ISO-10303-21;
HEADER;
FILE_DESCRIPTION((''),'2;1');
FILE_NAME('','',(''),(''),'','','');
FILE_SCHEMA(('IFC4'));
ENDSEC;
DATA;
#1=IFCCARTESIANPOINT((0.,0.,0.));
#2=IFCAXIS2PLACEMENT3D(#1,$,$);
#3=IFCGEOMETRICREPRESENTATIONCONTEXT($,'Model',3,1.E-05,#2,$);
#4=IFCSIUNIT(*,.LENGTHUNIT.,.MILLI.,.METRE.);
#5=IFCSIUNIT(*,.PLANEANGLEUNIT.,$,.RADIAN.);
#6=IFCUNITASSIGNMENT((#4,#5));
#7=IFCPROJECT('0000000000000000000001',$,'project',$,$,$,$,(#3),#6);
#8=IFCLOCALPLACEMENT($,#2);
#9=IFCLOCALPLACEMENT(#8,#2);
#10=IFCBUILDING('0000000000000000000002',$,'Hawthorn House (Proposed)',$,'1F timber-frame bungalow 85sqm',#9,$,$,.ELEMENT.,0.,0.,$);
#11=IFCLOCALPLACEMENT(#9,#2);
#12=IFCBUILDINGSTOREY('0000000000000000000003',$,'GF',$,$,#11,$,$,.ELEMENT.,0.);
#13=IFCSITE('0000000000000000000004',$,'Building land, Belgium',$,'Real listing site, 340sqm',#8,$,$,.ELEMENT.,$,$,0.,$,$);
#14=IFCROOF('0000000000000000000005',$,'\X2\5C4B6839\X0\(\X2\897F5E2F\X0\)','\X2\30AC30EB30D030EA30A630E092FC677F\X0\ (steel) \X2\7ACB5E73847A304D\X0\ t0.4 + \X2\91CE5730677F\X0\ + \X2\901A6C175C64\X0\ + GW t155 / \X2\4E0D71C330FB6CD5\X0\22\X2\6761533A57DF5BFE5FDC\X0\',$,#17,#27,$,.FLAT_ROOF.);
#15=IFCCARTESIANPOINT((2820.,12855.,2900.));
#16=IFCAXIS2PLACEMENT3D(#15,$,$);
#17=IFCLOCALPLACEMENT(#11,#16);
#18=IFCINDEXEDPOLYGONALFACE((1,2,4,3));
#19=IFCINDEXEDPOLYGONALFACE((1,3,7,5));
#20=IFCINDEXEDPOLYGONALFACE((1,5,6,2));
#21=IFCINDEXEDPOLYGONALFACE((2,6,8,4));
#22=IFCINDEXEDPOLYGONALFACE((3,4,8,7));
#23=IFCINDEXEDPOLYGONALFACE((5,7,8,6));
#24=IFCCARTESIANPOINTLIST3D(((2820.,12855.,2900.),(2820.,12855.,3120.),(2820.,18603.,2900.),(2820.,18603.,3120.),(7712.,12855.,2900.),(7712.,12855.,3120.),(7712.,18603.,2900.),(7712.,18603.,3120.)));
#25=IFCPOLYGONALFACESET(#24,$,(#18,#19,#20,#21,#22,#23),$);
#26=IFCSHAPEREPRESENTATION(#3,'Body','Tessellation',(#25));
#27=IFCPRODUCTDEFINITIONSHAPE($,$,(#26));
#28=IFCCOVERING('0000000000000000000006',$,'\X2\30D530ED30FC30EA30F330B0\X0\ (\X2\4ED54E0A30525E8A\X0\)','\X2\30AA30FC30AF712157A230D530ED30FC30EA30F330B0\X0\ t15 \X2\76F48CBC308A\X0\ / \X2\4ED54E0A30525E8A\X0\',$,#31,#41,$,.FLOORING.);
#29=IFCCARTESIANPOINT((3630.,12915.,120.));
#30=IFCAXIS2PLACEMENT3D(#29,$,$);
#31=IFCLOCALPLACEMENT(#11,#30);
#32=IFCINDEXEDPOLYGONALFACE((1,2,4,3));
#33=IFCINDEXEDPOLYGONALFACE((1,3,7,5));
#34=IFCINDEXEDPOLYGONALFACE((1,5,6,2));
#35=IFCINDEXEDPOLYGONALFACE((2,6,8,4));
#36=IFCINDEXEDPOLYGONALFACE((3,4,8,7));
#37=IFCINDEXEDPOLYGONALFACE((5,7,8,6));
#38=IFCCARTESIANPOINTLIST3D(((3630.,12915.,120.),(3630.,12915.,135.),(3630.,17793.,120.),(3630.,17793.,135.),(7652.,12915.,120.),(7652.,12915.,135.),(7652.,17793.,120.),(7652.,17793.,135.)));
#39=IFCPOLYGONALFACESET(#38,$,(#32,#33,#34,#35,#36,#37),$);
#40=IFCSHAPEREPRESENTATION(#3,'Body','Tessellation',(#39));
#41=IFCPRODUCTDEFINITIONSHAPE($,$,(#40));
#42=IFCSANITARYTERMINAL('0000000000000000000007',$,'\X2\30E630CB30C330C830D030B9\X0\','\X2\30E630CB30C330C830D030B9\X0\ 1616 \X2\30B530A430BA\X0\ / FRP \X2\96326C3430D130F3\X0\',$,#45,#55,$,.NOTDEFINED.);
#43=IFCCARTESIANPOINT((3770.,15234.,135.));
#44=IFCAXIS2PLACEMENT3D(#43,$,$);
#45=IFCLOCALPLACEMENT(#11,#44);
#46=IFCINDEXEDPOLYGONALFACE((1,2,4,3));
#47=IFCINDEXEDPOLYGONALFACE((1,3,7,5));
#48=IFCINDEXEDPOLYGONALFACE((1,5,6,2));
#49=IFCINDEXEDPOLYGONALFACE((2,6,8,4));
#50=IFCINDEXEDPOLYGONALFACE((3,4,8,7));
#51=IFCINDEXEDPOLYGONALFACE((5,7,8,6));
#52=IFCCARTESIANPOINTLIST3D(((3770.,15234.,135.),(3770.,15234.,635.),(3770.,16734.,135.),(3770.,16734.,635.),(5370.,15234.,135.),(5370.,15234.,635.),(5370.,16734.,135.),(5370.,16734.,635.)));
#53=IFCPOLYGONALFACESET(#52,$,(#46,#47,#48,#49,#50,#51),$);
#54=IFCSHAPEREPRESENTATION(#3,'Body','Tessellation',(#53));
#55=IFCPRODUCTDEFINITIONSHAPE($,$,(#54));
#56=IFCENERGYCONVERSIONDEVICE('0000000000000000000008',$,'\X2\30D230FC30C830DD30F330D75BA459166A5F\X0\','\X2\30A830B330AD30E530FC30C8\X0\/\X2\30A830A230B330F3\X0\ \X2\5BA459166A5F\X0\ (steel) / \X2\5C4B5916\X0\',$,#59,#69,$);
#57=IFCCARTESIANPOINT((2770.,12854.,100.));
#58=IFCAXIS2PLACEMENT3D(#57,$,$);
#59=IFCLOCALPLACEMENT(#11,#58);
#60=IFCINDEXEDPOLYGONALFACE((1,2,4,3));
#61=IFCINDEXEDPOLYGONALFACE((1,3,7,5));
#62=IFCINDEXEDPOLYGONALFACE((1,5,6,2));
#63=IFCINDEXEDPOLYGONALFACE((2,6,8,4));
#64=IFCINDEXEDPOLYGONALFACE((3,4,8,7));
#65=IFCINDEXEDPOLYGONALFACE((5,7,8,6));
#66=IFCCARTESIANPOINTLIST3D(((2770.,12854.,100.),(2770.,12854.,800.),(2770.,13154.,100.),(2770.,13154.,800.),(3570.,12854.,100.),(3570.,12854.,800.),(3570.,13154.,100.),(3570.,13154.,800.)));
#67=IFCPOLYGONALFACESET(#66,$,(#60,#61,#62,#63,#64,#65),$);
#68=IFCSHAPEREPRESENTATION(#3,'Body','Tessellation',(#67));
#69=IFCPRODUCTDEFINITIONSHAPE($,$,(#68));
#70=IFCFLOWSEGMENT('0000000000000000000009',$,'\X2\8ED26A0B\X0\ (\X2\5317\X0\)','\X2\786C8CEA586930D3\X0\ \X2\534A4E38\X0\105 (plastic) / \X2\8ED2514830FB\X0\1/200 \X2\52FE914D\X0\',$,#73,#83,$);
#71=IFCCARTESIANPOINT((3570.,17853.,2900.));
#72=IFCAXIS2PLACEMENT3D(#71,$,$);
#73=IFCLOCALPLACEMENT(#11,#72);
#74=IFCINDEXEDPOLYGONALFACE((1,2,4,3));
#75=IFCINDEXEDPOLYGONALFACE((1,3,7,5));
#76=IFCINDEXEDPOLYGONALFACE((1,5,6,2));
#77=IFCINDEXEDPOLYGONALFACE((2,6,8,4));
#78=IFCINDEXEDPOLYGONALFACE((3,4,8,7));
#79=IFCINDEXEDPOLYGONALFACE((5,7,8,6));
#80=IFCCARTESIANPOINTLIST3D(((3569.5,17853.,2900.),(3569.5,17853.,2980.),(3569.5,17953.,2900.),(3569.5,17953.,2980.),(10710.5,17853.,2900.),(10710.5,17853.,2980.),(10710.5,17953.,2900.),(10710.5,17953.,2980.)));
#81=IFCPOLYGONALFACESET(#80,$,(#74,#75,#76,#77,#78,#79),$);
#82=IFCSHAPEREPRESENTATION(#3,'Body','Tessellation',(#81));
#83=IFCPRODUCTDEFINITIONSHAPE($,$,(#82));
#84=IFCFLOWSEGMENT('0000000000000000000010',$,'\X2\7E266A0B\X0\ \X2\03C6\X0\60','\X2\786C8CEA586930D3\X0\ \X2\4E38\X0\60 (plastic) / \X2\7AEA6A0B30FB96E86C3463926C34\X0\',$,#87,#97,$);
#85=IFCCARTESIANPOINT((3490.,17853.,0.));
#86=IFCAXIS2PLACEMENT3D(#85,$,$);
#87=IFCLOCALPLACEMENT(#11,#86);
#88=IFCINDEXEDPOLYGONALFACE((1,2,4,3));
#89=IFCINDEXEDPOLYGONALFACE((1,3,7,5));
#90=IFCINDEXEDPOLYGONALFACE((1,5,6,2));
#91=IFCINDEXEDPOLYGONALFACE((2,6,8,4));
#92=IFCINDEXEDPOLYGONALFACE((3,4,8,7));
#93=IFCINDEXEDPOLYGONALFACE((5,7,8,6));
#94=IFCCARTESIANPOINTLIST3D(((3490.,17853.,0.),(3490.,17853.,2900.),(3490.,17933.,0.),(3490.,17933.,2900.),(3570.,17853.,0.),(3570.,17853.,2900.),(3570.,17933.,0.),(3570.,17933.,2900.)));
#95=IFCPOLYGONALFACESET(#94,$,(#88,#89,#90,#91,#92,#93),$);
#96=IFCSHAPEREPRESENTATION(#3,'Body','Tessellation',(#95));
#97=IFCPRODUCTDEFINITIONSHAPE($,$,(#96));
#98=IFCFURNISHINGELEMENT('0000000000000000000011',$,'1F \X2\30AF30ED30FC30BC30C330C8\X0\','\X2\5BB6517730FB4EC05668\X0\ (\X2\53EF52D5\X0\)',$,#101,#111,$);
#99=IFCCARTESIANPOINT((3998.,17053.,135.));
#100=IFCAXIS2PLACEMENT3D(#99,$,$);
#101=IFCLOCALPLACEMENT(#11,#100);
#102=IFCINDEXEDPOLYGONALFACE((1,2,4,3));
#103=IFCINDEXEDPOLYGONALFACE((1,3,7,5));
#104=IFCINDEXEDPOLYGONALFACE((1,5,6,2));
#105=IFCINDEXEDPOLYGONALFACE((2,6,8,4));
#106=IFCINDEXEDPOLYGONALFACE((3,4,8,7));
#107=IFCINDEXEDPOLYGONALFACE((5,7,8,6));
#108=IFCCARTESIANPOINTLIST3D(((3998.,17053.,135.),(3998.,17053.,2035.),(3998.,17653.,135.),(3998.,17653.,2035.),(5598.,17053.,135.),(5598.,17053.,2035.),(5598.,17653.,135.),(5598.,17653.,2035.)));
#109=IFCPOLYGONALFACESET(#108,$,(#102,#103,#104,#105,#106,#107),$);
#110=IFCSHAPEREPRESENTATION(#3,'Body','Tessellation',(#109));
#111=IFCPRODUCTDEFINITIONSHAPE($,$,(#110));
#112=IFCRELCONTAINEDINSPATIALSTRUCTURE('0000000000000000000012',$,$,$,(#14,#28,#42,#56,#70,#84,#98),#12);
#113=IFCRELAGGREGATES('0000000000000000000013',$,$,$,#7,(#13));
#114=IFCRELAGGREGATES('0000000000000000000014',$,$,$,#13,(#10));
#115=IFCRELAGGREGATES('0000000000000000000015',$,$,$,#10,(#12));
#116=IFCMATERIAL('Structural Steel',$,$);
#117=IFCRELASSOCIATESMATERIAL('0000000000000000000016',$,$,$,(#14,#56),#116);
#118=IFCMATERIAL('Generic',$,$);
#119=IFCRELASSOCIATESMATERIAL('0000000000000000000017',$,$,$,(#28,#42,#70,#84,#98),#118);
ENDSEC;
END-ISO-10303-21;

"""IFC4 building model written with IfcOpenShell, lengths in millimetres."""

from ifc_helpers import new_model, si_unit, frame, frame_2d, origin, place, context, project, spatial, rectangle, extrude, material, element, save


model = new_model("IFC4")

# Units and contexts
model_context = context("Model", 3, precision=1e-05, world=origin())
ifc_project = project(units=[si_unit("LENGTHUNIT", "METRE", prefix="MILLI"), si_unit("PLANEANGLEUNIT", "RADIAN")], contexts=[model_context])

# Site, building, storey
site_placement = place(None, origin())
site = spatial("IfcSite", under=ifc_project, at=site_placement, Name="Building land, Belgium", ObjectType="Real listing site, 340sqm", CompositionType="ELEMENT", RefElevation=0.0)
building_placement = place(site_placement, origin())
building = spatial("IfcBuilding", under=site, at=building_placement, Name="Hawthorn House (Proposed)", ObjectType="1F timber-frame bungalow 85sqm", CompositionType="ELEMENT", ElevationOfRefHeight=0.0, ElevationOfTerrain=0.0)
storey_placement = place(building_placement, origin())
storey = spatial("IfcBuildingStorey", under=building, at=storey_placement, Name="GF", CompositionType="ELEMENT", Elevation=0.0)

# Roof
ifc_material_1 = material(Name="Structural Steel")
roof_placement = place(storey_placement, frame((2820.0, 12855.0, 2900.0)))
element("IfcRoof", 1, at=roof_placement, inside=storey, material=ifc_material_1, Name="屋根(西帯)", Description="ガルバリウム鋼板 (steel) 立平葺き t0.4 + 野地板 + 通気層 + GW t155 / 不燃・法22条区域対応", PredefinedType="FLAT_ROOF", context=model_context, shape_type="SweptSolid", body=[
    extrude(rectangle(XDim=4892.0, YDim=5748.0, at=frame_2d((2446.0, 2874.0))), frame((2820.0, 12855.0, 2900.0)), (0.0, 0.0, 1.0), 220.0),
])

# Covering
ifc_material_2 = material(Name="Generic")
covering_placement = place(storey_placement, frame((3630.0, 12915.0, 120.0)))
element("IfcCovering", 2, at=covering_placement, inside=storey, material=ifc_material_2, Name="フローリング (仕上げ床)", Description="オーク無垢フローリング t15 直貼り / 仕上げ床", PredefinedType="FLOORING", context=model_context, shape_type="SweptSolid", body=[
    extrude(rectangle(XDim=4022.0, YDim=4878.0, at=frame_2d((2011.0, 2439.0))), frame((3630.0, 12915.0, 120.0)), (0.0, 0.0, 1.0), 15.0),
])

# Sanitary terminal
sanitary_terminal_placement = place(storey_placement, frame((3770.0, 15234.0, 135.0)))
element("IfcSanitaryTerminal", 3, at=sanitary_terminal_placement, inside=storey, material=ifc_material_2, Name="ユニットバス", Description="ユニットバス 1616 サイズ / FRP 防水パン", PredefinedType="NOTDEFINED", context=model_context, shape_type="SweptSolid", body=[
    extrude(rectangle(XDim=1600.0, YDim=1500.0, at=frame_2d((800.0, 750.0))), frame((3770.0, 15234.0, 135.0)), (0.0, 0.0, 1.0), 500.0),
])

# Energy conversion device
energy_conversion_device_placement = place(storey_placement, frame((2770.0, 12854.0, 100.0)))
element("IfcEnergyConversionDevice", 4, at=energy_conversion_device_placement, inside=storey, material=ifc_material_1, Name="ヒートポンプ室外機", Description="エコキュート/エアコン 室外機 (steel) / 屋外", context=model_context, shape_type="SweptSolid", body=[
    extrude(rectangle(XDim=800.0, YDim=300.0, at=frame_2d((400.0, 150.0))), frame((2770.0, 12854.0, 100.0)), (0.0, 0.0, 1.0), 700.0),
])

# Flow segments
flow_segment_1_placement = place(storey_placement, frame((3570.0, 17853.0, 2900.0)))
element("IfcFlowSegment", 5, at=flow_segment_1_placement, inside=storey, material=ifc_material_2, Name="軒樋 (北)", Description="硬質塩ビ 半丸105 (plastic) / 軒先・1/200 勾配", context=model_context, shape_type="SweptSolid", body=[
    extrude(rectangle(XDim=7141.0, YDim=100.0, at=frame_2d((3570.0, 50.0))), frame((3570.0, 17853.0, 2900.0)), (0.0, 0.0, 1.0), 80.0),
])
flow_segment_2_placement = place(storey_placement, frame((3490.0, 17853.0, 0.0)))
element("IfcFlowSegment", 6, at=flow_segment_2_placement, inside=storey, material=ifc_material_2, Name="縦樋 φ60", Description="硬質塩ビ 丸60 (plastic) / 竪樋・雨水排水", context=model_context, shape_type="SweptSolid", body=[
    extrude(rectangle(XDim=80.0, YDim=80.0, at=frame_2d((40.0, 40.0))), frame((3490.0, 17853.0, 0.0)), (0.0, 0.0, 1.0), 2900.0),
])

# Furnishing element
furnishing_placement = place(storey_placement, frame((3998.0, 17053.0, 135.0)))
element("IfcFurnishingElement", 7, at=furnishing_placement, inside=storey, material=ifc_material_2, Name="1F クローゼット", Description="家具・什器 (可動)", context=model_context, shape_type="SweptSolid", body=[
    extrude(rectangle(XDim=1600.0, YDim=600.0, at=frame_2d((800.0, 300.0))), frame((3998.0, 17053.0, 135.0)), (0.0, 0.0, 1.0), 1900.0),
])

save(model, "model.ifc")
